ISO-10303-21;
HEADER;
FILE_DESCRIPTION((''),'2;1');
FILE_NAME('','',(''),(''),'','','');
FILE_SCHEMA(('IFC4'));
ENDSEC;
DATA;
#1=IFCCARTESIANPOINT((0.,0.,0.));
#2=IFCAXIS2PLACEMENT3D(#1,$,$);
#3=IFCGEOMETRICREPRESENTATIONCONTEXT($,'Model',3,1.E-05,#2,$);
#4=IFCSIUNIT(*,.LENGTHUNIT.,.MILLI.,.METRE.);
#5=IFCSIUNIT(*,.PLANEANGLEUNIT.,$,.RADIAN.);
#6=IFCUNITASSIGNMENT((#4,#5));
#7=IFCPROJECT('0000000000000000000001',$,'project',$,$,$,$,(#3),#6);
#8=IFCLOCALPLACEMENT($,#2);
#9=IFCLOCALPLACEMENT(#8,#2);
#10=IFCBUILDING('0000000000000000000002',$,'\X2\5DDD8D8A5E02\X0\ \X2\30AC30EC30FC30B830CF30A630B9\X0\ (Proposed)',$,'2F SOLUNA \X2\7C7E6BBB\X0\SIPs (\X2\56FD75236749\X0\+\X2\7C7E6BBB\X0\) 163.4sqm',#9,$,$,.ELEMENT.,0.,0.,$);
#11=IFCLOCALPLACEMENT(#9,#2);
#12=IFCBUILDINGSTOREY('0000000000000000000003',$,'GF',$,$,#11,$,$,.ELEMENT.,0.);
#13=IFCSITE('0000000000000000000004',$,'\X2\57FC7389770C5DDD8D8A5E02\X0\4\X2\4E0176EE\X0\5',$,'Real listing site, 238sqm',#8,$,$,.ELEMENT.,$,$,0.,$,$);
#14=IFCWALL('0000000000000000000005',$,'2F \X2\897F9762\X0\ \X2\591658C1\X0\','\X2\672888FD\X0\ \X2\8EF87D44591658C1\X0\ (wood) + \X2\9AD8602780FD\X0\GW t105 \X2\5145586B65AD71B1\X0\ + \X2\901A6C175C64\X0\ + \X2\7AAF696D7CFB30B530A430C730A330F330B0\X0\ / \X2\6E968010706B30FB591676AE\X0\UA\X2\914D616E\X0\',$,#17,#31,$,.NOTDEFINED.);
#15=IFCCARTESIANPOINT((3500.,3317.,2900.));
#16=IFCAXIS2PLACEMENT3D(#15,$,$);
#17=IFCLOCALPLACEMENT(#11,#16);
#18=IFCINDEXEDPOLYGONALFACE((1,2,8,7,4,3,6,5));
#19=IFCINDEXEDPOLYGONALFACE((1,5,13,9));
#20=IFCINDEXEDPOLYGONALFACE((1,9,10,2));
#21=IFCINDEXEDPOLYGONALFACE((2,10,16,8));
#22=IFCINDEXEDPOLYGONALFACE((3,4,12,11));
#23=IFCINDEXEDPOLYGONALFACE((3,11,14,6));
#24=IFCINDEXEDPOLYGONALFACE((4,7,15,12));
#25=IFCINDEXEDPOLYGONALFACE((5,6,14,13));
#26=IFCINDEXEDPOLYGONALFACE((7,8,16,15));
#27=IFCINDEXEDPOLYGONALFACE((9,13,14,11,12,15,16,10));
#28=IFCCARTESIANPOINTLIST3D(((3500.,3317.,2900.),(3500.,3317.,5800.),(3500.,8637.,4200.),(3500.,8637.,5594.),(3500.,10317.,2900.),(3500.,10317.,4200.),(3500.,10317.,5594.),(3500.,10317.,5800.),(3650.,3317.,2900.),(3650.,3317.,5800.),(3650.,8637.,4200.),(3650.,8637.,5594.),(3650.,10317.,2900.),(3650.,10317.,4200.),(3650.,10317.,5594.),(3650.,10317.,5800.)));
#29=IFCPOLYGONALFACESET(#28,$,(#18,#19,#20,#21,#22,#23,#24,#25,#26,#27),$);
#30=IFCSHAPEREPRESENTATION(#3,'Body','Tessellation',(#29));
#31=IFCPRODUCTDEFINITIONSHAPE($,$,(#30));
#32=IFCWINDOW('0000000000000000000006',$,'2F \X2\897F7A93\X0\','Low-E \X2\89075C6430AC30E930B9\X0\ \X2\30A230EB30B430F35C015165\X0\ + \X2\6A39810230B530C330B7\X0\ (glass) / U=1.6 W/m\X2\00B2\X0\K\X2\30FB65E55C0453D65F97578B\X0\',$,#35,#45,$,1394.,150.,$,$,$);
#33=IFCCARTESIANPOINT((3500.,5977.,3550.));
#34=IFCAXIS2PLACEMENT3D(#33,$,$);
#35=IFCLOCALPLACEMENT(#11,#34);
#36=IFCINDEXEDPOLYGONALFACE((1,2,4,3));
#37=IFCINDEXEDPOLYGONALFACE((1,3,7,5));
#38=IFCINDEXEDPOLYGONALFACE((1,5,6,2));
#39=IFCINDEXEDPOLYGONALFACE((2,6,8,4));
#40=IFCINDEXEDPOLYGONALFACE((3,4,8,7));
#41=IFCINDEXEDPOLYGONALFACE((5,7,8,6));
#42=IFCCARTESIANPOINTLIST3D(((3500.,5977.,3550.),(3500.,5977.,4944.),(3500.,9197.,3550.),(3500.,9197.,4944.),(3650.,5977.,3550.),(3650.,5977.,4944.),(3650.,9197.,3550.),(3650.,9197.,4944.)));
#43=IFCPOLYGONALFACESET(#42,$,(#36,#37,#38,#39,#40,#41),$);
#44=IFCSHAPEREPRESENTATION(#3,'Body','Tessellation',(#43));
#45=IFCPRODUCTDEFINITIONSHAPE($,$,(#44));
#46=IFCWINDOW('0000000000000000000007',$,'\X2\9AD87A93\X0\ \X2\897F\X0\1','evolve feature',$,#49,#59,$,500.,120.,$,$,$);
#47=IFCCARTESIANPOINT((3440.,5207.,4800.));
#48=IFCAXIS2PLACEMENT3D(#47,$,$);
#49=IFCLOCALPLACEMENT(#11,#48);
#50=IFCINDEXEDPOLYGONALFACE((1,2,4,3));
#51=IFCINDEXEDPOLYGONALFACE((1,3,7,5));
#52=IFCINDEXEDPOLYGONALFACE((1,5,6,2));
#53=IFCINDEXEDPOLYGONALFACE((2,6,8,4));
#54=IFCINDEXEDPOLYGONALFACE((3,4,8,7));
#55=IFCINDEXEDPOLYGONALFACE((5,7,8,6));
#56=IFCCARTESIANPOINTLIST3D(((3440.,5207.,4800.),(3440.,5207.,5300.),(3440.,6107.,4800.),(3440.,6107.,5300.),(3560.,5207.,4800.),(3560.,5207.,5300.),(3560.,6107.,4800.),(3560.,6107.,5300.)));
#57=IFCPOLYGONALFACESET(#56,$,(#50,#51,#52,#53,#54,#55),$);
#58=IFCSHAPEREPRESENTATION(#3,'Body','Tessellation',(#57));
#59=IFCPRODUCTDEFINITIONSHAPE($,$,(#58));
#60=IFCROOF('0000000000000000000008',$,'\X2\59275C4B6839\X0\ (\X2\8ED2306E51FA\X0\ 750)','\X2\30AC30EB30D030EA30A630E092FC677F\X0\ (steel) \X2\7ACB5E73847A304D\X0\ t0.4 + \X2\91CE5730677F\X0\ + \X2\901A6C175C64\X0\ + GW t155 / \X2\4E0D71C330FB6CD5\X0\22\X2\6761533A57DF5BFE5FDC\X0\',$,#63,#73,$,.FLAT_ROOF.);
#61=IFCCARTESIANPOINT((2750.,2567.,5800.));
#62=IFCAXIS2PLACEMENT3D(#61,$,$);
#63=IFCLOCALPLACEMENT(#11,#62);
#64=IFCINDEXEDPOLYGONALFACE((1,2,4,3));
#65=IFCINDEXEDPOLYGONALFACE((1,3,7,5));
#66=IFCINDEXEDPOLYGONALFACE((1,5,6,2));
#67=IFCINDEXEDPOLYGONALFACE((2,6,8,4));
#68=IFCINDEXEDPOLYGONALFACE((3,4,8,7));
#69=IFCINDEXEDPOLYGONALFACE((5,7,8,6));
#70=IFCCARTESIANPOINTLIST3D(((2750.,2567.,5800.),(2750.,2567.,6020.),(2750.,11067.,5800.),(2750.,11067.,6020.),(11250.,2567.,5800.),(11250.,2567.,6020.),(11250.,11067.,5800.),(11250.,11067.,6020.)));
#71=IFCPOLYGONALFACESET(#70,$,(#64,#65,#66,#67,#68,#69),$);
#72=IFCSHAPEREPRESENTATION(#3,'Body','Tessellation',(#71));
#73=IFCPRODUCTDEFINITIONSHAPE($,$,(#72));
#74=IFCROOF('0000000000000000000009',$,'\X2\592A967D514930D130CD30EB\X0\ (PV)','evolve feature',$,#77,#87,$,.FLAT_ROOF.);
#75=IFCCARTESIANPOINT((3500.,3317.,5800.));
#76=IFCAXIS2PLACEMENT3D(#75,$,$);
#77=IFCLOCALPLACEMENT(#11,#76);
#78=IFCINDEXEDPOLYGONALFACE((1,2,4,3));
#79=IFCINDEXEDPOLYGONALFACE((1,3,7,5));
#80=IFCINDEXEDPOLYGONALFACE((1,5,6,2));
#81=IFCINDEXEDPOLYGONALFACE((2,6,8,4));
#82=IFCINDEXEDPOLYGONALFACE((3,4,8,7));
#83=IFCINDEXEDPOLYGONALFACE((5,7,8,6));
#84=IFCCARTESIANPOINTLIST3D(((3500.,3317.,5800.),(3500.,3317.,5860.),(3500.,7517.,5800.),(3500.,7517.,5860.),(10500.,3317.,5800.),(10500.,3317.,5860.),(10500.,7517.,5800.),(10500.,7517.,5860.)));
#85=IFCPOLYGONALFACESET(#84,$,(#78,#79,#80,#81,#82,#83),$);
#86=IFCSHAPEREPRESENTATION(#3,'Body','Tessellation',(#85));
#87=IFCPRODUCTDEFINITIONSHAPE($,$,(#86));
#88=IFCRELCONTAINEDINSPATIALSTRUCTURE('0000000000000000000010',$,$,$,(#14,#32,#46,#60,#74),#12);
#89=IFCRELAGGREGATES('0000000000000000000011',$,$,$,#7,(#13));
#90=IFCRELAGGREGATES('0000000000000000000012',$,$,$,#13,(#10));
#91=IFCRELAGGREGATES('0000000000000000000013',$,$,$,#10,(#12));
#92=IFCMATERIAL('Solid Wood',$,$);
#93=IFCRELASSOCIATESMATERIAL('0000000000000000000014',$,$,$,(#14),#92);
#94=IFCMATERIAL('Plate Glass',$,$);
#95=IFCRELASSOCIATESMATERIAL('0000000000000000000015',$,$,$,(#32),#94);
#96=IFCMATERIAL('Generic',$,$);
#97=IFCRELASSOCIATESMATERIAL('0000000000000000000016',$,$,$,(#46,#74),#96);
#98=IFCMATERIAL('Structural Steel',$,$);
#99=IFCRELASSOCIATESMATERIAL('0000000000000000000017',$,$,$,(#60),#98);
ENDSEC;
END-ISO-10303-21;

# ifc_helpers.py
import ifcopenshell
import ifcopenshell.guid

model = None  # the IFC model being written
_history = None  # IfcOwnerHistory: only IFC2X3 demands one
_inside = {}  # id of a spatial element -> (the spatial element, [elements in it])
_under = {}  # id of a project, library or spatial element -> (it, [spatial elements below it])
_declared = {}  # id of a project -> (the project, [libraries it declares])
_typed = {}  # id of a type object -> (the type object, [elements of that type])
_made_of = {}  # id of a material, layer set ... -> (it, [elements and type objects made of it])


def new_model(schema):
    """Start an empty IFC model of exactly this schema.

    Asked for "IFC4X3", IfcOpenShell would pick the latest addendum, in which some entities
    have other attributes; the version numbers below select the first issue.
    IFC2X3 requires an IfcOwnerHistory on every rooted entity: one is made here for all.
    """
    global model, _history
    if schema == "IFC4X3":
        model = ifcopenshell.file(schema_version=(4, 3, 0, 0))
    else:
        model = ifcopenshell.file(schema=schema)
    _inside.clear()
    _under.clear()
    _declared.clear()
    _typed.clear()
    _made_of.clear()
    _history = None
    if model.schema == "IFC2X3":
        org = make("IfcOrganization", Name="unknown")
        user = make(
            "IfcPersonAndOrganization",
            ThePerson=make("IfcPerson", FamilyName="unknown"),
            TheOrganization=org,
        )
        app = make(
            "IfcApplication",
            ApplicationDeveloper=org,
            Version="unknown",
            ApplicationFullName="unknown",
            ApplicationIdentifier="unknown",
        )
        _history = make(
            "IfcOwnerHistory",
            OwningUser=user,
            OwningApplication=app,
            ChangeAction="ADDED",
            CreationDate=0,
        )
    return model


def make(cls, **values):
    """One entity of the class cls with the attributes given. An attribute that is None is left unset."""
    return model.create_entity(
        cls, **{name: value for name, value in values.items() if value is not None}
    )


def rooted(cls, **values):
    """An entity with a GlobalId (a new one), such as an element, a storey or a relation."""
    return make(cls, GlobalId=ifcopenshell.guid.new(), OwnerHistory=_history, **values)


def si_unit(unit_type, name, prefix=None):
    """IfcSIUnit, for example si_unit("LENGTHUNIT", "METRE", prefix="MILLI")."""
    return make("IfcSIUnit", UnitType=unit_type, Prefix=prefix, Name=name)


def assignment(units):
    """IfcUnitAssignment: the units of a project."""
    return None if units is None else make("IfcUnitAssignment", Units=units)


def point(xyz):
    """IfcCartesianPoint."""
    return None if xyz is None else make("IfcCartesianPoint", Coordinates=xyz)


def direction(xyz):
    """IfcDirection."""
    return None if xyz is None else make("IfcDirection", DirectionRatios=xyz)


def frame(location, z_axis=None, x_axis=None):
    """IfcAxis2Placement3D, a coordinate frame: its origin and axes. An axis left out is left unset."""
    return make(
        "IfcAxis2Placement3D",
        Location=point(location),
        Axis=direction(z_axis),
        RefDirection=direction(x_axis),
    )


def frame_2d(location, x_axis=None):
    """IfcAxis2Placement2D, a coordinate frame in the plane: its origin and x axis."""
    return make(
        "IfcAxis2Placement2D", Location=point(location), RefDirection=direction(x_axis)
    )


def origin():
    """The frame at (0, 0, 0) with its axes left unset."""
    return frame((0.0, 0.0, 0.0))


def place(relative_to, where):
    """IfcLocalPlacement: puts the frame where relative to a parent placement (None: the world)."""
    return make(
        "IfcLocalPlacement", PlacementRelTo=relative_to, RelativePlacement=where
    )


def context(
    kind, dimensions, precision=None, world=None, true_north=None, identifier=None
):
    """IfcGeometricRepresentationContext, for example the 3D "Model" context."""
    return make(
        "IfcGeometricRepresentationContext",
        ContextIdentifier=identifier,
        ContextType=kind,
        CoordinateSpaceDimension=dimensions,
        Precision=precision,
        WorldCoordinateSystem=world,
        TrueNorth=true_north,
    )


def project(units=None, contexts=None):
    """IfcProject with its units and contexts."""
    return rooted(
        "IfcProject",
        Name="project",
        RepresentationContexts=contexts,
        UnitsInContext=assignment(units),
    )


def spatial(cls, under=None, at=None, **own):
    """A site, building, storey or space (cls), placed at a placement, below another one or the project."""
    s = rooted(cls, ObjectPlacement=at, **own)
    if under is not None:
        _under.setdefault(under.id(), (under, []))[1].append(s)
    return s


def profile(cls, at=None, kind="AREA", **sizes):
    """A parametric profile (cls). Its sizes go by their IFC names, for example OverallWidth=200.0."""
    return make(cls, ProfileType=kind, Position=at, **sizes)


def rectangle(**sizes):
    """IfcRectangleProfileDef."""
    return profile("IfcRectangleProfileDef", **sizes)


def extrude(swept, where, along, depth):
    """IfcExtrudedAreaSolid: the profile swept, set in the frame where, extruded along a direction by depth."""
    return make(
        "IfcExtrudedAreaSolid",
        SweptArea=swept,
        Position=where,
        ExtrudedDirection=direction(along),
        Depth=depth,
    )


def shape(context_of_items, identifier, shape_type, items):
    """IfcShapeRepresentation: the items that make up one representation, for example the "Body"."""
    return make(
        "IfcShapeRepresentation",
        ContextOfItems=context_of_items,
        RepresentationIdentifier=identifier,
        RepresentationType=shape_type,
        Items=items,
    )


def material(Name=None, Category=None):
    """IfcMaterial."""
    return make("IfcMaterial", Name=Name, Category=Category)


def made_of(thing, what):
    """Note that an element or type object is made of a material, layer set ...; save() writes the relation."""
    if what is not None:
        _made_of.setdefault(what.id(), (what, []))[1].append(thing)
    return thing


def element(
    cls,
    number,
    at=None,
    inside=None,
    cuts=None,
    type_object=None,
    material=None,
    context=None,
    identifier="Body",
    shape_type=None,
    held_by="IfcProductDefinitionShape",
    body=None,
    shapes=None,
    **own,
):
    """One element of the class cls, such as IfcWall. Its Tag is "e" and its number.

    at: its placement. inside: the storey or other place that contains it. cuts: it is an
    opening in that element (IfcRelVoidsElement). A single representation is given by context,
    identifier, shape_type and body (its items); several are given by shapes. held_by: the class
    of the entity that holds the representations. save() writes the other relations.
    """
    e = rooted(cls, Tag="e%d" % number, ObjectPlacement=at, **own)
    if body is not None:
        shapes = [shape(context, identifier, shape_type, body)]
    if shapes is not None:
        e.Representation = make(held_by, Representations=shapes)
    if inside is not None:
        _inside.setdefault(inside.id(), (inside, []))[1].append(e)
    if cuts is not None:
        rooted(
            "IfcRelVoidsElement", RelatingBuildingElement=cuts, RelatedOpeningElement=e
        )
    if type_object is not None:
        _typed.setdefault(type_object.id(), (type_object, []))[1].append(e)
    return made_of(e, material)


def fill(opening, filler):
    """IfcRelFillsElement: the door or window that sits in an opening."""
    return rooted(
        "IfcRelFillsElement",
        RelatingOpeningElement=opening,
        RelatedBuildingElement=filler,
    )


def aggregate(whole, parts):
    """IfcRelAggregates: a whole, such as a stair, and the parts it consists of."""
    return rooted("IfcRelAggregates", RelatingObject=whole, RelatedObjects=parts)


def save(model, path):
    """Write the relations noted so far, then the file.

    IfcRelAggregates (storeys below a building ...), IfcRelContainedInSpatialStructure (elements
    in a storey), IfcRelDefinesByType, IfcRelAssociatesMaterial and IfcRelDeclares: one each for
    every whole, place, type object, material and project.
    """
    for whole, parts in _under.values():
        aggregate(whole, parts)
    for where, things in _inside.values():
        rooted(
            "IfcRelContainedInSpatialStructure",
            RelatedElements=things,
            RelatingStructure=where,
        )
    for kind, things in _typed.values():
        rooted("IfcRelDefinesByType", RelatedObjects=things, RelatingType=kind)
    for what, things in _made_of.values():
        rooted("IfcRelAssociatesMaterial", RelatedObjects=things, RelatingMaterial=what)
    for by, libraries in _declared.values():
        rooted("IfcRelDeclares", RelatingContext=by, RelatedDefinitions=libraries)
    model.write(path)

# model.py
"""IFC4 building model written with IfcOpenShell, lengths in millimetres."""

from ifc_helpers import new_model, si_unit, frame, frame_2d, origin, place, context, project, spatial, rectangle, extrude, material, element, fill, save


model = new_model("IFC4")

# Units and contexts
model_context = context("Model", 3, precision=1e-05, world=origin())
ifc_project = project(units=[si_unit("LENGTHUNIT", "METRE", prefix="MILLI"), si_unit("PLANEANGLEUNIT", "RADIAN")], contexts=[model_context])

# Site, building, storey
site_placement = place(None, origin())
site = spatial("IfcSite", under=ifc_project, at=site_placement, Name="埼玉県川越市4丁目5", ObjectType="Real listing site, 238sqm", CompositionType="ELEMENT", RefElevation=0.0)
building_placement = place(site_placement, origin())
building = spatial("IfcBuilding", under=site, at=building_placement, Name="川越市 ガレージハウス (Proposed)", ObjectType="2F SOLUNA 籾殻SIPs (国産杉+籾殻) 163.4sqm", CompositionType="ELEMENT", ElevationOfRefHeight=0.0, ElevationOfTerrain=0.0)
storey_placement = place(building_placement, origin())
storey = spatial("IfcBuildingStorey", under=building, at=storey_placement, Name="GF", CompositionType="ELEMENT", Elevation=0.0)

# Shared definitions
ifc_material_1 = material(Name="Solid Wood")
ifc_material_2 = material(Name="Generic")

# Shared definitions
ifc_material_3 = material(Name="Plate Glass")

# Wall, openings, windows
wall_1_placement = place(storey_placement, frame((3500.0, 3317.0, 2900.0)))
wall_1 = element("IfcWall", 1, at=wall_1_placement, inside=storey, material=ifc_material_1, Name="2F 西面 外壁", Description="木製 軸組外壁 (wood) + 高性能GW t105 充填断熱 + 通気層 + 窯業系サイディング / 準耐火・外皮UA配慮", PredefinedType="NOTDEFINED", context=model_context, shape_type="SweptSolid", body=[
    extrude(rectangle(XDim=150.0, YDim=7000.0, at=frame_2d((75.0, 3500.0))), frame((3500.0, 3317.0, 2900.0)), (0.0, 0.0, 1.0), 2900.0),
])
opening_1_placement = place(storey_placement, frame((3500.0, 5977.0, 3550.0)))
opening_1 = element("IfcOpeningElement", 2, at=opening_1_placement, cuts=wall_1, PredefinedType="NOTDEFINED", context=model_context, shape_type="SweptSolid", body=[
    extrude(rectangle(XDim=150.0, YDim=3220.0, at=frame_2d((75.0, 1610.0))), frame((3500.0, 5977.0, 3550.0)), (0.0, 0.0, 1.0), 1394.0),
])
opening_2_placement = place(storey_placement, frame((3440.0, 5207.0, 4800.0)))
opening_2 = element("IfcOpeningElement", 3, at=opening_2_placement, cuts=wall_1, PredefinedType="NOTDEFINED", context=model_context, shape_type="SweptSolid", body=[
    extrude(rectangle(XDim=120.0, YDim=900.0, at=frame_2d((60.0, 450.0))), frame((3440.0, 5207.0, 4800.0)), (0.0, 0.0, 1.0), 500.0),
])
window_1_placement = place(storey_placement, frame((3500.0, 5977.0, 3550.0)))
window_1 = element("IfcWindow", 4, at=window_1_placement, inside=storey, material=ifc_material_3, Name="2F 西窓", Description="Low-E 複層ガラス アルゴン封入 + 樹脂サッシ (glass) / U=1.6 W/m²K・日射取得型", OverallHeight=1394.0, OverallWidth=150.0, context=model_context, shape_type="SweptSolid", body=[
    extrude(rectangle(XDim=150.0, YDim=3220.0, at=frame_2d((75.0, 1610.0))), frame((3500.0, 5977.0, 3550.0)), (0.0, 0.0, 1.0), 1394.0),
])
fill(opening_1, window_1)
window_2_placement = place(storey_placement, frame((3440.0, 5207.0, 4800.0)))
window_2 = element("IfcWindow", 5, at=window_2_placement, inside=storey, material=ifc_material_2, Name="高窓 西1", Description="evolve feature", OverallHeight=500.0, OverallWidth=120.0, context=model_context, shape_type="SweptSolid", body=[
    extrude(rectangle(XDim=120.0, YDim=900.0, at=frame_2d((60.0, 450.0))), frame((3440.0, 5207.0, 4800.0)), (0.0, 0.0, 1.0), 500.0),
])
fill(opening_2, window_2)

# Roofs
ifc_material_4 = material(Name="Structural Steel")
roof_1_placement = place(storey_placement, frame((2750.0, 2567.0, 5800.0)))
element("IfcRoof", 6, at=roof_1_placement, inside=storey, material=ifc_material_4, Name="大屋根 (軒の出 750)", Description="ガルバリウム鋼板 (steel) 立平葺き t0.4 + 野地板 + 通気層 + GW t155 / 不燃・法22条区域対応", PredefinedType="FLAT_ROOF", context=model_context, shape_type="SweptSolid", body=[
    extrude(rectangle(XDim=8500.0, YDim=8500.0, at=frame_2d((4250.0, 4250.0))), frame((2750.0, 2567.0, 5800.0)), (0.0, 0.0, 1.0), 220.0),
])
roof_2_placement = place(storey_placement, frame((3500.0, 3317.0, 5800.0)))
element("IfcRoof", 7, at=roof_2_placement, inside=storey, material=ifc_material_2, Name="太陽光パネル (PV)", Description="evolve feature", PredefinedType="FLAT_ROOF", context=model_context, shape_type="SweptSolid", body=[
    extrude(rectangle(XDim=7000.0, YDim=4200.0, at=frame_2d((3500.0, 2100.0))), frame((3500.0, 3317.0, 5800.0)), (0.0, 0.0, 1.0), 60.0),
])

save(model, "model.ifc")
